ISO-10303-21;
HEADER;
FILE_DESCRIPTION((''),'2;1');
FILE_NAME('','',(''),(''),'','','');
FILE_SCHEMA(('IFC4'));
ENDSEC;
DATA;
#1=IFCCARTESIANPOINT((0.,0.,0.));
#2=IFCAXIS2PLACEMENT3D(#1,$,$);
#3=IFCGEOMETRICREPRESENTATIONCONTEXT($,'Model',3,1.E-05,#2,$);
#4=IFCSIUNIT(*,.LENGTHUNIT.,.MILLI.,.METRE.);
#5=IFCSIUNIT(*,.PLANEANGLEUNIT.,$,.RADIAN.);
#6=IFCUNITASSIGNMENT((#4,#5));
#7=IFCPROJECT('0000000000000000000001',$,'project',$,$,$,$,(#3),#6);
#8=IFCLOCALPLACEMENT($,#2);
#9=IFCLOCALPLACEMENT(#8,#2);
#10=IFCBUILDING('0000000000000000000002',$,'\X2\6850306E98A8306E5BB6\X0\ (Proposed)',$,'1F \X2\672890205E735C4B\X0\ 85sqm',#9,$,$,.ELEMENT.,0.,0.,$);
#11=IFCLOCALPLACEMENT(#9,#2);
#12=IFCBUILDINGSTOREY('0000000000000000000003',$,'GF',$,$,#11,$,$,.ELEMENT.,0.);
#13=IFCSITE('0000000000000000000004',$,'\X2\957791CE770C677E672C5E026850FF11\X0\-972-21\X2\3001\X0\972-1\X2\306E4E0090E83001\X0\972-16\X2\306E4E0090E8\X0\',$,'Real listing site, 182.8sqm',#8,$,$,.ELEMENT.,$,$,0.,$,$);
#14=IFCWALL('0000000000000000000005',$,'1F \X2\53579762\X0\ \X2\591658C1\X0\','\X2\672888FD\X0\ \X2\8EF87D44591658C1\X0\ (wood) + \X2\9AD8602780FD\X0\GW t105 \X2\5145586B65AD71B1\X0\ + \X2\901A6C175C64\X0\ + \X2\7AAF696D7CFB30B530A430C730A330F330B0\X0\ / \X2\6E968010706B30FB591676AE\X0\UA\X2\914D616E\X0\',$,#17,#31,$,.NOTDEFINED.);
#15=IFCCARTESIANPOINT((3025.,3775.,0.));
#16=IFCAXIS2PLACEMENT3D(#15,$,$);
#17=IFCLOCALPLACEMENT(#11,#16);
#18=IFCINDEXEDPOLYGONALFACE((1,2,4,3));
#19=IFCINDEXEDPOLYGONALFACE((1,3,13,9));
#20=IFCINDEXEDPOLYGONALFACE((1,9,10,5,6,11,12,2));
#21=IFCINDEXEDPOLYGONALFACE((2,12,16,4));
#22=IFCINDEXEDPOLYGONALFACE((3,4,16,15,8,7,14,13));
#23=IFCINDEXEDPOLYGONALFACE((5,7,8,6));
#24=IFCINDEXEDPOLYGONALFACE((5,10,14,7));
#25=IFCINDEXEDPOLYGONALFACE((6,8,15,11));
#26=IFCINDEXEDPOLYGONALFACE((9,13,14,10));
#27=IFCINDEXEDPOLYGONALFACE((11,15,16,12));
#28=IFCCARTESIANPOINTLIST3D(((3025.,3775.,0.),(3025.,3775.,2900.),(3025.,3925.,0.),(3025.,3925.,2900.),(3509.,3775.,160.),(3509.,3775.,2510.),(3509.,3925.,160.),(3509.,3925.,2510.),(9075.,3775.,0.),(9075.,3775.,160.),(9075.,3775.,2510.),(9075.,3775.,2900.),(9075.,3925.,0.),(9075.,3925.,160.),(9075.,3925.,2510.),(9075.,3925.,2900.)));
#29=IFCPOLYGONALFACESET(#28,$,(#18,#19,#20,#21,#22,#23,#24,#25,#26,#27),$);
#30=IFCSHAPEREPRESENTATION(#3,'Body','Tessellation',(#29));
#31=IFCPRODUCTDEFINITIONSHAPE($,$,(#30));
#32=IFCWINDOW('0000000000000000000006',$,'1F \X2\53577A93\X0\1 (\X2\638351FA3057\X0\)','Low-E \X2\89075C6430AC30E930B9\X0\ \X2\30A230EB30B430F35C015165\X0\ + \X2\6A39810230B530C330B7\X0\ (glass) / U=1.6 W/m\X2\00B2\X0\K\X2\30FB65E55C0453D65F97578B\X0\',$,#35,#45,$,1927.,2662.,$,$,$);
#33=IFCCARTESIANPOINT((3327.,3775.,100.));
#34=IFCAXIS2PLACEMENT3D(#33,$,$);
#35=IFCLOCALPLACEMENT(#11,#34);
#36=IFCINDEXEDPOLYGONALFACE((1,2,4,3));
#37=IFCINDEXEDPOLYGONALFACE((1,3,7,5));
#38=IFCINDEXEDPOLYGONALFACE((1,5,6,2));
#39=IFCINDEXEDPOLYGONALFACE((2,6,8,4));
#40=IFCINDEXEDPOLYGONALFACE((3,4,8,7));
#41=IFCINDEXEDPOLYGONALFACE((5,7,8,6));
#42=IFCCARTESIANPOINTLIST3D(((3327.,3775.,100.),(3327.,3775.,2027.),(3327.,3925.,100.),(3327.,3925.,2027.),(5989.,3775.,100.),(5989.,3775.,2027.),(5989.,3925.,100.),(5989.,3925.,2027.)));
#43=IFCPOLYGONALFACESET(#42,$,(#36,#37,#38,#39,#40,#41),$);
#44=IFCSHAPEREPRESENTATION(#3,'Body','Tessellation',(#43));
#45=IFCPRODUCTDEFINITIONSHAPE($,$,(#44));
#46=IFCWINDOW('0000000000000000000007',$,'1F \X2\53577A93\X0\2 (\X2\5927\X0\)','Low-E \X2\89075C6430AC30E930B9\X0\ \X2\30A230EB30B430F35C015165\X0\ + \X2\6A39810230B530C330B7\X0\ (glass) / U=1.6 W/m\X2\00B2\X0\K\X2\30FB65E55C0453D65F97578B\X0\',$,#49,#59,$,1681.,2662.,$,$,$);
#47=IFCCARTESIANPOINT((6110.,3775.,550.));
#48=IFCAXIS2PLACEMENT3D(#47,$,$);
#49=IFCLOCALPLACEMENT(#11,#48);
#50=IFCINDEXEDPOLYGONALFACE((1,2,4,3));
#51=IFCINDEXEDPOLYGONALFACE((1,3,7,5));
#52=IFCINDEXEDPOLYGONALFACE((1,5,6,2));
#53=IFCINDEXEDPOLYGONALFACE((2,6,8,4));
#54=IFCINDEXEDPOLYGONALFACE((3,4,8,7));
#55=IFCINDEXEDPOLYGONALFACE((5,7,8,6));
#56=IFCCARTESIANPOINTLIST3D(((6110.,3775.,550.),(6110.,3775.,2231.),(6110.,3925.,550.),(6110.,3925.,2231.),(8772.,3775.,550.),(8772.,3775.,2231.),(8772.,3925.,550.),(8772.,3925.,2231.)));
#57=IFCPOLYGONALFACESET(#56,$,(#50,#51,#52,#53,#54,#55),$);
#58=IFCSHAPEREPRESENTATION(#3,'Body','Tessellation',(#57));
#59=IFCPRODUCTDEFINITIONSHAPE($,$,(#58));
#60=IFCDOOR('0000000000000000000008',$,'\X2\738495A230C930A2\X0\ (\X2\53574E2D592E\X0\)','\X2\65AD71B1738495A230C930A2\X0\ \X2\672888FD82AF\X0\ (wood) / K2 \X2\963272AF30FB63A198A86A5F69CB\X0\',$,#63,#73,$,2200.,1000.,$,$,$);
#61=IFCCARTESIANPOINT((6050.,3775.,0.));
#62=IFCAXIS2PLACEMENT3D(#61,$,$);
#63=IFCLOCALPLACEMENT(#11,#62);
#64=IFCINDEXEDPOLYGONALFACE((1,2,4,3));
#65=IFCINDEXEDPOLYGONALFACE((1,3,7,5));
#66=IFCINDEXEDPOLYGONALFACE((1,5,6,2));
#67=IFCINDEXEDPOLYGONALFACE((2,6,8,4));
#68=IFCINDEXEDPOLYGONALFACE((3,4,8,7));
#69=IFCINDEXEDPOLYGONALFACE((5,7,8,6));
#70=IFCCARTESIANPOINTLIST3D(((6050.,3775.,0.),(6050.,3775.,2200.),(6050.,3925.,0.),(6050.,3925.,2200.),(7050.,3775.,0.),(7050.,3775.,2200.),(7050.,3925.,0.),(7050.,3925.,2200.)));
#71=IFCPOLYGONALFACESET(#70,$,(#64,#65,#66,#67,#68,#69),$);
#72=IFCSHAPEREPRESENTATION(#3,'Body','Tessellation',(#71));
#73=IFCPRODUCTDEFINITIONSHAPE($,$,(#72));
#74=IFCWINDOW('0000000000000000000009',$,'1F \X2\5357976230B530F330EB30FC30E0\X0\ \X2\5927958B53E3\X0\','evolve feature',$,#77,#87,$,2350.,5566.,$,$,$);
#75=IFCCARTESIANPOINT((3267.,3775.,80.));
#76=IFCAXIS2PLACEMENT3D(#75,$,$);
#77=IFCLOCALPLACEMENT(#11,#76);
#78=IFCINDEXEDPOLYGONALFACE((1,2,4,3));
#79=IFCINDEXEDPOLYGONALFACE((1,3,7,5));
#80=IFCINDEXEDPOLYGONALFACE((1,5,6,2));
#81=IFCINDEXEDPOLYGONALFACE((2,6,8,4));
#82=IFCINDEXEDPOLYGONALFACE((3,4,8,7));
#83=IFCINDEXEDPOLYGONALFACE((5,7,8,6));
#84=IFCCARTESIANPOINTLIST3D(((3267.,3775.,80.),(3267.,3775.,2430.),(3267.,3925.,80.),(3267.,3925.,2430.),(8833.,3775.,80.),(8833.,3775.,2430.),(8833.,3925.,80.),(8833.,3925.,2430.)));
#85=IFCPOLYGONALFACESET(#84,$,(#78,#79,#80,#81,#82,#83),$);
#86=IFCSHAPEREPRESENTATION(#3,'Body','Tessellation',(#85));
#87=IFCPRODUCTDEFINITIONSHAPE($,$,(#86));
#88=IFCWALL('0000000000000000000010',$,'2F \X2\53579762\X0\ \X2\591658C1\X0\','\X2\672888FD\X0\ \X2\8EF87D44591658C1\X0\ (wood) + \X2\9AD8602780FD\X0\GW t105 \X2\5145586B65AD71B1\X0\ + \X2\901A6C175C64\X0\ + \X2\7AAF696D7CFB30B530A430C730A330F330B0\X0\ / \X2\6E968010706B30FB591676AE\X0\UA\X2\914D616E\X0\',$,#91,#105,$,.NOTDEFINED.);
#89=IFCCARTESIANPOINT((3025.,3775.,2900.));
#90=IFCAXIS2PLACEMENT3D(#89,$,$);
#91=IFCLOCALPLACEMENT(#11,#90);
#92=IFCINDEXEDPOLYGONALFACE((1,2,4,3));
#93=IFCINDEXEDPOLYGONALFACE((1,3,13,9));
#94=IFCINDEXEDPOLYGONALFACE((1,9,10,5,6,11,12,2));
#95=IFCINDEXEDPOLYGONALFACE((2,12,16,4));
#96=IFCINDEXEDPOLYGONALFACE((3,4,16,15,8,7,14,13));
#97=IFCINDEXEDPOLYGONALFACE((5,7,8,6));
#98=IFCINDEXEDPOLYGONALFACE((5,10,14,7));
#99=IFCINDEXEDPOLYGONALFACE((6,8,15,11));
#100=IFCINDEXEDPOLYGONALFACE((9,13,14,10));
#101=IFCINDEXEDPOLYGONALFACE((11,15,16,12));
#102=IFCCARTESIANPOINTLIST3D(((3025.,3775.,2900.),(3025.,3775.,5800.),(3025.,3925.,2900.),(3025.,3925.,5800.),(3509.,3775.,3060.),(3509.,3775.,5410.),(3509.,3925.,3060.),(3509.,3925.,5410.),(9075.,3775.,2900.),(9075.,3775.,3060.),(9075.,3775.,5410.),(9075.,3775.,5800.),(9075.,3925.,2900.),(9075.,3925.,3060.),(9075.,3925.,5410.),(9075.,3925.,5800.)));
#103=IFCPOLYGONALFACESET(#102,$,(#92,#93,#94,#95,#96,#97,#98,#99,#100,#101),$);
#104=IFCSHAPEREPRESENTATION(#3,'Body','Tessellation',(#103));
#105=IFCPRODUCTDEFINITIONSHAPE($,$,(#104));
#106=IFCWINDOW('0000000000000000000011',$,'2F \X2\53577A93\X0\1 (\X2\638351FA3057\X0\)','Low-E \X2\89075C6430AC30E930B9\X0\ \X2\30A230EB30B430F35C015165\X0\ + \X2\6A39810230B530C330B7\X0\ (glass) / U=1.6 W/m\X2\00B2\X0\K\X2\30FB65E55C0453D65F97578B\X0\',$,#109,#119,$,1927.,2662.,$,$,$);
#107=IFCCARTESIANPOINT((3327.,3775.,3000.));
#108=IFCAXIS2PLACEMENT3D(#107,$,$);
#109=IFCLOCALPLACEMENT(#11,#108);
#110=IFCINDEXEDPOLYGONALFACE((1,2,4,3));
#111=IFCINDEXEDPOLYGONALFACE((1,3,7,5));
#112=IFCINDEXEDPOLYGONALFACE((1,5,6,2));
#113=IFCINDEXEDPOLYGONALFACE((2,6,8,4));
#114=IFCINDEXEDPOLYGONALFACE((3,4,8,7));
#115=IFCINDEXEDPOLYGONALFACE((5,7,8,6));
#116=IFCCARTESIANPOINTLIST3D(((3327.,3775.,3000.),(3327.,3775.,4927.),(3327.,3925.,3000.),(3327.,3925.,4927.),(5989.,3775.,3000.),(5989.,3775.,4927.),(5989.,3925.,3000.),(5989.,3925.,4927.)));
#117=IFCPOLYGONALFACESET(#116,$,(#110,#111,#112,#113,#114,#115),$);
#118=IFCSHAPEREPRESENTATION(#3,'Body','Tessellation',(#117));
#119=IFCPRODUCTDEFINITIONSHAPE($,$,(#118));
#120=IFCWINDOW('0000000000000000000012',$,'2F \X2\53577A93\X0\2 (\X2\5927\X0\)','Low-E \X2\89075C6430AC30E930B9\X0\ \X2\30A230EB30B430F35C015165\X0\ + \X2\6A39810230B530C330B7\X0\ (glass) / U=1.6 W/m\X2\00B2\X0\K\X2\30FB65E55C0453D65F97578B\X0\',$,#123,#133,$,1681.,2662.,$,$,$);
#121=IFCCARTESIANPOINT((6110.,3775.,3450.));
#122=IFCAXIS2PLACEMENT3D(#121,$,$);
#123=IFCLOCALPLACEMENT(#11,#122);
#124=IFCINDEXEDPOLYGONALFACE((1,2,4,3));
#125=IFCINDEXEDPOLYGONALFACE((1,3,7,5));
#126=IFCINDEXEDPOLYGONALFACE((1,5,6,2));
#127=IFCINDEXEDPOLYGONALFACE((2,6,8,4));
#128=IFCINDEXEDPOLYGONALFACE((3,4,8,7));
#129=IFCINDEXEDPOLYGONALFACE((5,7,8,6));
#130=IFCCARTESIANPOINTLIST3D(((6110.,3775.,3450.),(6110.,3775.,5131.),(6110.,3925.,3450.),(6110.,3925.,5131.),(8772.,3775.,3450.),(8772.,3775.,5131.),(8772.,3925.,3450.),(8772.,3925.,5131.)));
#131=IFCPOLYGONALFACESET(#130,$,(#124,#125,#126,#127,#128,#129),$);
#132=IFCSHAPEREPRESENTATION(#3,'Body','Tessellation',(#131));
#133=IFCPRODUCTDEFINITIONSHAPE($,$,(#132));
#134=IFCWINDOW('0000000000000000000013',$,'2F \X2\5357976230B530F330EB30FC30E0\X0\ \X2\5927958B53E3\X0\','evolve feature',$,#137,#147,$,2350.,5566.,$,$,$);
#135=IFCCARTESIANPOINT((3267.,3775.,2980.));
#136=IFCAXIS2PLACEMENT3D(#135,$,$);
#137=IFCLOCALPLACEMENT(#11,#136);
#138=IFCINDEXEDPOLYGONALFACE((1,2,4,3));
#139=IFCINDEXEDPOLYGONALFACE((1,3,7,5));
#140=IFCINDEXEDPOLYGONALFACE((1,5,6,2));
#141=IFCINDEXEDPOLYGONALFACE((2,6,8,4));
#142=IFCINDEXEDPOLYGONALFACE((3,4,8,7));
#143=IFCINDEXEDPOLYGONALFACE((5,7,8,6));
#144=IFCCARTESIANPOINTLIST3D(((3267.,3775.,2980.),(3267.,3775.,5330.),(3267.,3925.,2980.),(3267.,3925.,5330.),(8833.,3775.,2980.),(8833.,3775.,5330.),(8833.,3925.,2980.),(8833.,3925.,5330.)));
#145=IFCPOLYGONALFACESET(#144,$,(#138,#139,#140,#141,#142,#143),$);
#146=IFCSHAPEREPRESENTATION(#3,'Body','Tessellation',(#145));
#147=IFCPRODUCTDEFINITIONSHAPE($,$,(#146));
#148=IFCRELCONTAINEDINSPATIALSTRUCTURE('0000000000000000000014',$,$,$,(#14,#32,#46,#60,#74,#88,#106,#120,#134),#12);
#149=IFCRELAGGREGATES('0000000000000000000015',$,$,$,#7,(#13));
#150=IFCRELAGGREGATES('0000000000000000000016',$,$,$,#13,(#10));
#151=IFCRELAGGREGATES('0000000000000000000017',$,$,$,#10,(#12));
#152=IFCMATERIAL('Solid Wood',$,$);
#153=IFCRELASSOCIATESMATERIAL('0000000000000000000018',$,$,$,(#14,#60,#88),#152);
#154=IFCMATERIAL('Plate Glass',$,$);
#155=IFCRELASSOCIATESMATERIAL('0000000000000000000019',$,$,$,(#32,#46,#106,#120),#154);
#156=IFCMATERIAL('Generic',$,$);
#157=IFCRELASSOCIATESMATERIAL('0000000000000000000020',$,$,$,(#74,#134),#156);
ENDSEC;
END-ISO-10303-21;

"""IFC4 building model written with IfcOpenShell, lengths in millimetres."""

from ifc_helpers import new_model, si_unit, frame, frame_2d, origin, place, context, project, spatial, rectangle, extrude, material, element, fill, save


model = new_model("IFC4")

# Units and contexts
model_context = context("Model", 3, precision=1e-05, world=origin())
ifc_project = project(units=[si_unit("LENGTHUNIT", "METRE", prefix="MILLI"), si_unit("PLANEANGLEUNIT", "RADIAN")], contexts=[model_context])

# Site, building, storey
site_placement = place(None, origin())
site = spatial("IfcSite", under=ifc_project, at=site_placement, Name="長野県松本市桐１-972-21、972-1の一部、972-16の一部", ObjectType="Real listing site, 182.8sqm", CompositionType="ELEMENT", RefElevation=0.0)
building_placement = place(site_placement, origin())
building = spatial("IfcBuilding", under=site, at=building_placement, Name="桐の風の家 (Proposed)", ObjectType="1F 木造平屋 85sqm", CompositionType="ELEMENT", ElevationOfRefHeight=0.0, ElevationOfTerrain=0.0)
storey_placement = place(building_placement, origin())
storey = spatial("IfcBuildingStorey", under=building, at=storey_placement, Name="GF", CompositionType="ELEMENT", Elevation=0.0)

# Shared definitions
ifc_material_1 = material(Name="Solid Wood")
ifc_material_2 = material(Name="Generic")

# Wall, openings, windows, door
wall_1_placement = place(storey_placement, frame((3025.0, 3775.0, 0.0)))
wall_1 = element("IfcWall", 1, at=wall_1_placement, inside=storey, material=ifc_material_1, Name="1F 南面 外壁", Description="木製 軸組外壁 (wood) + 高性能GW t105 充填断熱 + 通気層 + 窯業系サイディング / 準耐火・外皮UA配慮", PredefinedType="NOTDEFINED", context=model_context, shape_type="SweptSolid", body=[
    extrude(rectangle(XDim=6050.0, YDim=150.0, at=frame_2d((3025.0, 75.0))), frame((3025.0, 3775.0, 0.0)), (0.0, 0.0, 1.0), 2900.0),
])
opening_1_placement = place(storey_placement, frame((3327.0, 3775.0, 100.0)))
opening_1 = element("IfcOpeningElement", 2, at=opening_1_placement, cuts=wall_1, PredefinedType="NOTDEFINED", context=model_context, shape_type="SweptSolid", body=[
    extrude(rectangle(XDim=2662.0, YDim=150.0, at=frame_2d((1331.0, 75.0))), frame((3327.0, 3775.0, 100.0)), (0.0, 0.0, 1.0), 1927.0),
])
opening_2_placement = place(storey_placement, frame((6110.0, 3775.0, 550.0)))
opening_2 = element("IfcOpeningElement", 3, at=opening_2_placement, cuts=wall_1, PredefinedType="NOTDEFINED", context=model_context, shape_type="SweptSolid", body=[
    extrude(rectangle(XDim=2662.0, YDim=150.0, at=frame_2d((1331.0, 75.0))), frame((6110.0, 3775.0, 550.0)), (0.0, 0.0, 1.0), 1681.0),
])
opening_3_placement = place(storey_placement, frame((6050.0, 3775.0, 0.0)))
opening_3 = element("IfcOpeningElement", 4, at=opening_3_placement, cuts=wall_1, PredefinedType="NOTDEFINED", context=model_context, shape_type="SweptSolid", body=[
    extrude(rectangle(XDim=1000.0, YDim=150.0, at=frame_2d((500.0, 75.0))), frame((6050.0, 3775.0, 0.0)), (0.0, 0.0, 1.0), 2200.0),
])
opening_4_placement = place(storey_placement, frame((3267.0, 3775.0, 80.0)))
opening_4 = element("IfcOpeningElement", 5, at=opening_4_placement, cuts=wall_1, PredefinedType="NOTDEFINED", context=model_context, shape_type="SweptSolid", body=[
    extrude(rectangle(XDim=5566.0, YDim=150.0, at=frame_2d((2783.0, 75.0))), frame((3267.0, 3775.0, 80.0)), (0.0, 0.0, 1.0), 2350.0),
])
ifc_material_3 = material(Name="Plate Glass")
window_1_placement = place(storey_placement, frame((3327.0, 3775.0, 100.0)))
window_1 = element("IfcWindow", 6, at=window_1_placement, inside=storey, material=ifc_material_3, Name="1F 南窓1 (掃出し)", Description="Low-E 複層ガラス アルゴン封入 + 樹脂サッシ (glass) / U=1.6 W/m²K・日射取得型", OverallHeight=1927.0, OverallWidth=2662.0, context=model_context, shape_type="SweptSolid", body=[
    extrude(rectangle(XDim=2662.0, YDim=150.0, at=frame_2d((1331.0, 75.0))), frame((3327.0, 3775.0, 100.0)), (0.0, 0.0, 1.0), 1927.0),
])
fill(opening_1, window_1)
window_2_placement = place(storey_placement, frame((6110.0, 3775.0, 550.0)))
window_2 = element("IfcWindow", 7, at=window_2_placement, inside=storey, material=ifc_material_3, Name="1F 南窓2 (大)", Description="Low-E 複層ガラス アルゴン封入 + 樹脂サッシ (glass) / U=1.6 W/m²K・日射取得型", OverallHeight=1681.0, OverallWidth=2662.0, context=model_context, shape_type="SweptSolid", body=[
    extrude(rectangle(XDim=2662.0, YDim=150.0, at=frame_2d((1331.0, 75.0))), frame((6110.0, 3775.0, 550.0)), (0.0, 0.0, 1.0), 1681.0),
])
fill(opening_2, window_2)
door_placement = place(storey_placement, frame((6050.0, 3775.0, 0.0)))
door = element("IfcDoor", 8, at=door_placement, inside=storey, material=ifc_material_1, Name="玄関ドア (南中央)", Description="断熱玄関ドア 木製芯 (wood) / K2 防犯・採風機構", OverallHeight=2200.0, OverallWidth=1000.0, context=model_context, shape_type="SweptSolid", body=[
    extrude(rectangle(XDim=1000.0, YDim=150.0, at=frame_2d((500.0, 75.0))), frame((6050.0, 3775.0, 0.0)), (0.0, 0.0, 1.0), 2200.0),
])
fill(opening_3, door)
window_3_placement = place(storey_placement, frame((3267.0, 3775.0, 80.0)))
window_3 = element("IfcWindow", 9, at=window_3_placement, inside=storey, material=ifc_material_2, Name="1F 南面サンルーム 大開口", Description="evolve feature", OverallHeight=2350.0, OverallWidth=5566.0, context=model_context, shape_type="SweptSolid", body=[
    extrude(rectangle(XDim=5566.0, YDim=150.0, at=frame_2d((2783.0, 75.0))), frame((3267.0, 3775.0, 80.0)), (0.0, 0.0, 1.0), 2350.0),
])
fill(opening_4, window_3)

# Wall, openings, windows
wall_2_placement = place(storey_placement, frame((3025.0, 3775.0, 2900.0)))
wall_2 = element("IfcWall", 10, at=wall_2_placement, inside=storey, material=ifc_material_1, Name="2F 南面 外壁", Description="木製 軸組外壁 (wood) + 高性能GW t105 充填断熱 + 通気層 + 窯業系サイディング / 準耐火・外皮UA配慮", PredefinedType="NOTDEFINED", context=model_context, shape_type="SweptSolid", body=[
    extrude(rectangle(XDim=6050.0, YDim=150.0, at=frame_2d((3025.0, 75.0))), frame((3025.0, 3775.0, 2900.0)), (0.0, 0.0, 1.0), 2900.0),
])
opening_5_placement = place(storey_placement, frame((3327.0, 3775.0, 3000.0)))
opening_5 = element("IfcOpeningElement", 11, at=opening_5_placement, cuts=wall_2, PredefinedType="NOTDEFINED", context=model_context, shape_type="SweptSolid", body=[
    extrude(rectangle(XDim=2662.0, YDim=150.0, at=frame_2d((1331.0, 75.0))), frame((3327.0, 3775.0, 3000.0)), (0.0, 0.0, 1.0), 1927.0),
])
opening_6_placement = place(storey_placement, frame((6110.0, 3775.0, 3450.0)))
opening_6 = element("IfcOpeningElement", 12, at=opening_6_placement, cuts=wall_2, PredefinedType="NOTDEFINED", context=model_context, shape_type="SweptSolid", body=[
    extrude(rectangle(XDim=2662.0, YDim=150.0, at=frame_2d((1331.0, 75.0))), frame((6110.0, 3775.0, 3450.0)), (0.0, 0.0, 1.0), 1681.0),
])
opening_7_placement = place(storey_placement, frame((3267.0, 3775.0, 2980.0)))
opening_7 = element("IfcOpeningElement", 13, at=opening_7_placement, cuts=wall_2, PredefinedType="NOTDEFINED", context=model_context, shape_type="SweptSolid", body=[
    extrude(rectangle(XDim=5566.0, YDim=150.0, at=frame_2d((2783.0, 75.0))), frame((3267.0, 3775.0, 2980.0)), (0.0, 0.0, 1.0), 2350.0),
])
window_4_placement = place(storey_placement, frame((3327.0, 3775.0, 3000.0)))
window_4 = element("IfcWindow", 14, at=window_4_placement, inside=storey, material=ifc_material_3, Name="2F 南窓1 (掃出し)", Description="Low-E 複層ガラス アルゴン封入 + 樹脂サッシ (glass) / U=1.6 W/m²K・日射取得型", OverallHeight=1927.0, OverallWidth=2662.0, context=model_context, shape_type="SweptSolid", body=[
    extrude(rectangle(XDim=2662.0, YDim=150.0, at=frame_2d((1331.0, 75.0))), frame((3327.0, 3775.0, 3000.0)), (0.0, 0.0, 1.0), 1927.0),
])
fill(opening_5, window_4)
window_5_placement = place(storey_placement, frame((6110.0, 3775.0, 3450.0)))
window_5 = element("IfcWindow", 15, at=window_5_placement, inside=storey, material=ifc_material_3, Name="2F 南窓2 (大)", Description="Low-E 複層ガラス アルゴン封入 + 樹脂サッシ (glass) / U=1.6 W/m²K・日射取得型", OverallHeight=1681.0, OverallWidth=2662.0, context=model_context, shape_type="SweptSolid", body=[
    extrude(rectangle(XDim=2662.0, YDim=150.0, at=frame_2d((1331.0, 75.0))), frame((6110.0, 3775.0, 3450.0)), (0.0, 0.0, 1.0), 1681.0),
])
fill(opening_6, window_5)
window_6_placement = place(storey_placement, frame((3267.0, 3775.0, 2980.0)))
window_6 = element("IfcWindow", 16, at=window_6_placement, inside=storey, material=ifc_material_2, Name="2F 南面サンルーム 大開口", Description="evolve feature", OverallHeight=2350.0, OverallWidth=5566.0, context=model_context, shape_type="SweptSolid", body=[
    extrude(rectangle(XDim=5566.0, YDim=150.0, at=frame_2d((2783.0, 75.0))), frame((3267.0, 3775.0, 2980.0)), (0.0, 0.0, 1.0), 2350.0),
])
fill(opening_7, window_6)

save(model, "model.ifc")
